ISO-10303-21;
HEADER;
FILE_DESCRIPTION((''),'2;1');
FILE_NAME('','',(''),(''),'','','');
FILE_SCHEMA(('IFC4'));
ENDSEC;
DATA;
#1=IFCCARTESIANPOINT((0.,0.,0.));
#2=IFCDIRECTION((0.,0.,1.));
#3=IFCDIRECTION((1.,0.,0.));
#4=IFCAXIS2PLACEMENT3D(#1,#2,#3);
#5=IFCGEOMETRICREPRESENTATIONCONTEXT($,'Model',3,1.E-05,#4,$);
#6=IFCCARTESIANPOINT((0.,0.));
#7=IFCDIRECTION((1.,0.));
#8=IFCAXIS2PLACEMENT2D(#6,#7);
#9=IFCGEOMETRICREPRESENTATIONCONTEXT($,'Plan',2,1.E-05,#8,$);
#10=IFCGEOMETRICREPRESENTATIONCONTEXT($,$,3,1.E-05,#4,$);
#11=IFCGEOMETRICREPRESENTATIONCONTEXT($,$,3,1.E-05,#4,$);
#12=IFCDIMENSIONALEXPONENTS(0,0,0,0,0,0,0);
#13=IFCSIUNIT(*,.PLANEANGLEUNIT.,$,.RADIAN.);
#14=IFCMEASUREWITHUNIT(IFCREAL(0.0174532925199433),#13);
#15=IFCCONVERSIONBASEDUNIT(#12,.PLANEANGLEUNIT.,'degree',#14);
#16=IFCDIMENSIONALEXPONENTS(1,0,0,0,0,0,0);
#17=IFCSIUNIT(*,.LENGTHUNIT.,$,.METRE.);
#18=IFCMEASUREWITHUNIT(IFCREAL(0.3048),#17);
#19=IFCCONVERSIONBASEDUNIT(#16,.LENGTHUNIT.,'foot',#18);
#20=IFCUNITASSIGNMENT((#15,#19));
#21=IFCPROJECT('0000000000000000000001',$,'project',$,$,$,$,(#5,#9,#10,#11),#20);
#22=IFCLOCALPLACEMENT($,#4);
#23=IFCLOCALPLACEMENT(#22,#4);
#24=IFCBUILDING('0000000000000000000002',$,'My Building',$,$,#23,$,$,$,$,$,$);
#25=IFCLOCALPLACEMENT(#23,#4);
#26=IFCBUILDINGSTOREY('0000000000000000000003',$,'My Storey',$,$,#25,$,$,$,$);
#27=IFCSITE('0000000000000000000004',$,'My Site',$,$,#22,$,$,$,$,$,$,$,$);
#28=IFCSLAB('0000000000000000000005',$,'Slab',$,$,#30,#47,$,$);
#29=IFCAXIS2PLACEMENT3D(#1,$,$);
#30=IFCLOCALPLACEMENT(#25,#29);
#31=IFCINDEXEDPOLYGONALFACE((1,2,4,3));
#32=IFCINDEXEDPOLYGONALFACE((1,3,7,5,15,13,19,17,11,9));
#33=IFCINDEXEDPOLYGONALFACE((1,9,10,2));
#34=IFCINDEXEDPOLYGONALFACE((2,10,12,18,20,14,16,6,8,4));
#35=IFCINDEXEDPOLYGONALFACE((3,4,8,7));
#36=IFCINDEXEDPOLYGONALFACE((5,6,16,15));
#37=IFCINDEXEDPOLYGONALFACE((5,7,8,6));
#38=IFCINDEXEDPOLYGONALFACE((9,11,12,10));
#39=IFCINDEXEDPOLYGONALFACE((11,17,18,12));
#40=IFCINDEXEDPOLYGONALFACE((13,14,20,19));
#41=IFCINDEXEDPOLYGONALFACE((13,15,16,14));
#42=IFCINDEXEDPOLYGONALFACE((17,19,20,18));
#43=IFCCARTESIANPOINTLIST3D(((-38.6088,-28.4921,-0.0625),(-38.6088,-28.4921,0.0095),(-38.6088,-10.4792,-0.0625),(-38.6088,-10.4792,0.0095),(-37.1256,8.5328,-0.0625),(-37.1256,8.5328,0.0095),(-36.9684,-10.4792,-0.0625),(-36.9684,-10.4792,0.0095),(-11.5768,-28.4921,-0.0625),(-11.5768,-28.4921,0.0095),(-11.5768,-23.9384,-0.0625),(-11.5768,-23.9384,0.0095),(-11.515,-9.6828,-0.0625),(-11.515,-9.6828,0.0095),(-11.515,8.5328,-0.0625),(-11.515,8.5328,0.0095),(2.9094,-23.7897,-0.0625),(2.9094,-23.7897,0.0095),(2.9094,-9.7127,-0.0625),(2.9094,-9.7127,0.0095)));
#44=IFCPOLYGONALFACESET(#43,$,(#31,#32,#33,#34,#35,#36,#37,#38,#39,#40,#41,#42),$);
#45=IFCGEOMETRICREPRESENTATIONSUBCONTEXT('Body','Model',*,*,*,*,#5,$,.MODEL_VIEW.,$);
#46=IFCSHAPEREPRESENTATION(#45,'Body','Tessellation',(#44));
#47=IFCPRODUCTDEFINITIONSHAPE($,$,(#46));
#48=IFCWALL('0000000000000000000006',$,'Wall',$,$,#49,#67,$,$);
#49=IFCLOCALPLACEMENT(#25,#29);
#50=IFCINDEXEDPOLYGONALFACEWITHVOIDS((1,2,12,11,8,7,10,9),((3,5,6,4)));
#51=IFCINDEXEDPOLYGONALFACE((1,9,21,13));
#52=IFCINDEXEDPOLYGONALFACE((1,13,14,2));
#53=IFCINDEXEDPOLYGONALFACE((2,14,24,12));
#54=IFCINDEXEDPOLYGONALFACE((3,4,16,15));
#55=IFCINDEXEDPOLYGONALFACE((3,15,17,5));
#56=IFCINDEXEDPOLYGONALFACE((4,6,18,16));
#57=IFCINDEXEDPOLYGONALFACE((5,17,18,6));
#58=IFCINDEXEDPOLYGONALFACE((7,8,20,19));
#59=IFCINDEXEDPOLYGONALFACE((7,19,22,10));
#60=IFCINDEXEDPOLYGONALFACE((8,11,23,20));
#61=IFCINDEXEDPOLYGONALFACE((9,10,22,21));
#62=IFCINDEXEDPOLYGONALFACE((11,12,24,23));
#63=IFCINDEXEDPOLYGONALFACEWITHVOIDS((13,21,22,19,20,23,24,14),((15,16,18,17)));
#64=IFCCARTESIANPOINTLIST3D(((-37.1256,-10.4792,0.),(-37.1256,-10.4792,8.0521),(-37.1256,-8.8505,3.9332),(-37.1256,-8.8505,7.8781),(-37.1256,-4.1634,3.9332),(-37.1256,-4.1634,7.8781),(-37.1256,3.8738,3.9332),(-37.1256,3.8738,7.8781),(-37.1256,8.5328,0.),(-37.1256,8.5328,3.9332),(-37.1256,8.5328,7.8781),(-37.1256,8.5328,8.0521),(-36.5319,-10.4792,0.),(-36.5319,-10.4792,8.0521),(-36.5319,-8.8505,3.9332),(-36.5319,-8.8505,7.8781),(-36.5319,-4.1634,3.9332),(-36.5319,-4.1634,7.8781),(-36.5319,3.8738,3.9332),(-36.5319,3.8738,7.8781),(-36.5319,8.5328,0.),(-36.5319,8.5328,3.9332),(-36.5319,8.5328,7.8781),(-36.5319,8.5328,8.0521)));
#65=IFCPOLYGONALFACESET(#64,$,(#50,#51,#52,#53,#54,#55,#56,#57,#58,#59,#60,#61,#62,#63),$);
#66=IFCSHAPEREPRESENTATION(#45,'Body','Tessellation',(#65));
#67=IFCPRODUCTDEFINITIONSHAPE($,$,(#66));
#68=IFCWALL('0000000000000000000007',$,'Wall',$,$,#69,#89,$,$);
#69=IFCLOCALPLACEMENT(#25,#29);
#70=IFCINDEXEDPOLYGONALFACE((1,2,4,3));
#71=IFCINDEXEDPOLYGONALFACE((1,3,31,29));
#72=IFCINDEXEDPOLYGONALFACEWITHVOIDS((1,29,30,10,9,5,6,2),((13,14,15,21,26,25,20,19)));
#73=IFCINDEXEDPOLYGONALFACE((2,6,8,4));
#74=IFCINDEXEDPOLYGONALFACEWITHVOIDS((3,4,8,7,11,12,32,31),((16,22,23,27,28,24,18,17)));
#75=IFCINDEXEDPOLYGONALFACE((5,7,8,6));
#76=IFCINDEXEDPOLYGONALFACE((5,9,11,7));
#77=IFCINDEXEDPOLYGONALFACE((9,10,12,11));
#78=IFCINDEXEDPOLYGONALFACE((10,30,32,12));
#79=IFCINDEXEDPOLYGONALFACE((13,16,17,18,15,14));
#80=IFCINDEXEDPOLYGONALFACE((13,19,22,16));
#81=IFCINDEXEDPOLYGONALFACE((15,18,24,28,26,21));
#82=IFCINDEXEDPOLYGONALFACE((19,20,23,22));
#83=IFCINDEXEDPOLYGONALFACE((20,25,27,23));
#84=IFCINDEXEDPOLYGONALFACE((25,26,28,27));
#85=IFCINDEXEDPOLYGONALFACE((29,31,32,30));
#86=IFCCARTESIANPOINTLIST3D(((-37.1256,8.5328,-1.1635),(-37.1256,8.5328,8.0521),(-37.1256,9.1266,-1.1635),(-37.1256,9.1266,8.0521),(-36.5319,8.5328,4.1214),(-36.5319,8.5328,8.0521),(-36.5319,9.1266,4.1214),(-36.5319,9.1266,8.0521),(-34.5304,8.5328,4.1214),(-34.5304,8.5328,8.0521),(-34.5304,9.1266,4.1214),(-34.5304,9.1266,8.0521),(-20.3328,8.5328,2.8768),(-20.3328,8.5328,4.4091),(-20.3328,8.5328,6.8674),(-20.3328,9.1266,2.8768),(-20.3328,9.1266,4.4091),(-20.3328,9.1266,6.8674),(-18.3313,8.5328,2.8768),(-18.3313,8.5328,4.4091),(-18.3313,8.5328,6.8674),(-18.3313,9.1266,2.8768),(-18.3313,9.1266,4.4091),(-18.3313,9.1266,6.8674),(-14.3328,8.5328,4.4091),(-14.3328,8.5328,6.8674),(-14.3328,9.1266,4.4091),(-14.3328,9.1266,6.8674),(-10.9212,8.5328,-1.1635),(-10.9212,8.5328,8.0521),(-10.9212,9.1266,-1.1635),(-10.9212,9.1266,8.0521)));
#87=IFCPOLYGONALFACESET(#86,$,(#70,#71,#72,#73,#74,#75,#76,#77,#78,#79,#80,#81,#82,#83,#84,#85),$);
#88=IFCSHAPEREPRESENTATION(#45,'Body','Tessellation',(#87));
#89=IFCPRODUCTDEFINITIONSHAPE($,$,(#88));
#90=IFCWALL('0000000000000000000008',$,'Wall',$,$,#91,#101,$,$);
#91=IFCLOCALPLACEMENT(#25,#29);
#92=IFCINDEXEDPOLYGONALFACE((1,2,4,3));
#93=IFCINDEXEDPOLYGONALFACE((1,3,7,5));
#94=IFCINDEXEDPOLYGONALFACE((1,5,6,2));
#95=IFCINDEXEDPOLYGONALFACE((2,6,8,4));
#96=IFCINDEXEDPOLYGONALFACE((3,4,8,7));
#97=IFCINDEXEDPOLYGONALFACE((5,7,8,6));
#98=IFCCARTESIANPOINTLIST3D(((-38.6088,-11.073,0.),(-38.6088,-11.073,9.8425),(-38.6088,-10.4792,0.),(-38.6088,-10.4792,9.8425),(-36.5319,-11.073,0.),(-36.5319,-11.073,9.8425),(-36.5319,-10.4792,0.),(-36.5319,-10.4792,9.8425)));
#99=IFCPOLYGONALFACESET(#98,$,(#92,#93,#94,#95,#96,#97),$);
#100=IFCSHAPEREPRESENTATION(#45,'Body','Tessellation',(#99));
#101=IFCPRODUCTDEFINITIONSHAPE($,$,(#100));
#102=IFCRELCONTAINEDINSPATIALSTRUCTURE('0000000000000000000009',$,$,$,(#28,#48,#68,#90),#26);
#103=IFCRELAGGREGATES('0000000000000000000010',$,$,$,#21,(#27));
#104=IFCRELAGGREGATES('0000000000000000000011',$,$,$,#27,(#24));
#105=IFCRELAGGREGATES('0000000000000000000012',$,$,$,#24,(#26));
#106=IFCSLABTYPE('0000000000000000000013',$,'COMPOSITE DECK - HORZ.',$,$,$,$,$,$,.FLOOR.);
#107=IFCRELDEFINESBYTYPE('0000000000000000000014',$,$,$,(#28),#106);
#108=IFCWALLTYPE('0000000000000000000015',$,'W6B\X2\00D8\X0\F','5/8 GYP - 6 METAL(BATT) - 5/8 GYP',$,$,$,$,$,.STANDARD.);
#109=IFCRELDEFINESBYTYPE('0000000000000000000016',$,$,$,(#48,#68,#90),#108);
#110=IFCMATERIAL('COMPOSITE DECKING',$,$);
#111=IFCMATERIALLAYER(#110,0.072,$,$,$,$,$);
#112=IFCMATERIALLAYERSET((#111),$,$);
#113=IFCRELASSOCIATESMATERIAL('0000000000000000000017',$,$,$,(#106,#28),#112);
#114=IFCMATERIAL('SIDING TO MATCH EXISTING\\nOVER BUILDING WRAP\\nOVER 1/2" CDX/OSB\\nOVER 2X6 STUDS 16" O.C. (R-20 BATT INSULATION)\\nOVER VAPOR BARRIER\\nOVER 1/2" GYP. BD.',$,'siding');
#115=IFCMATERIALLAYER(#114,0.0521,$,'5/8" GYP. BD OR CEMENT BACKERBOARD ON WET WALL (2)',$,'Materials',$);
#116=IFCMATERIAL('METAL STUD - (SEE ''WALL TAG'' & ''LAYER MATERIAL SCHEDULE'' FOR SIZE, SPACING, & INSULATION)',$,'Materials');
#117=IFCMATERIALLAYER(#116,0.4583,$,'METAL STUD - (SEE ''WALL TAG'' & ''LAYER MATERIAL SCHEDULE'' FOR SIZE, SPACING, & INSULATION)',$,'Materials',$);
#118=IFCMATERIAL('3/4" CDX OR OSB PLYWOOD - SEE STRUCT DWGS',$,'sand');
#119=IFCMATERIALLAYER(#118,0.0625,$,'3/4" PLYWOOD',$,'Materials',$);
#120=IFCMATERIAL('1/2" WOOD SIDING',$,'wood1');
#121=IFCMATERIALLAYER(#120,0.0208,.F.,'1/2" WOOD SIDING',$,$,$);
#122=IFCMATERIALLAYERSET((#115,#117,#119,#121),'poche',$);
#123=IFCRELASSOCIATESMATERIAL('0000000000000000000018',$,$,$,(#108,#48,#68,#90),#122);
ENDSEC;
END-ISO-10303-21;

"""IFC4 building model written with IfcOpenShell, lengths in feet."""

from ifc_helpers import new_model, entity, si_unit, converted_unit, frame, origin_with_axes, origin_2d_with_axis, place, context, subcontext, project, spatial, line, indexed_curve, outline, extrude, source, transform, mapped, material, layer, layer_set, layer_usage, type_object, element, save


model = new_model("IFC4")

# Units and contexts
model_context = context("Model", 3, precision=1e-05, world=origin_with_axes())
plan_context = context("Plan", 2, precision=1e-05, world=origin_2d_with_axis())
context_of_model_1 = context(None, 3, precision=1e-05, world=origin_with_axes())
context_of_model_2 = context(None, 3, precision=1e-05, world=origin_with_axes())
body_context = subcontext(model_context, "Body", "Model", "MODEL_VIEW")
ifc_project = project(units=[converted_unit("PLANEANGLEUNIT", "degree", entity("IfcReal", 0.0174532925199433), si_unit("PLANEANGLEUNIT", "RADIAN"), dimensions=[0, 0, 0, 0, 0, 0, 0]), converted_unit("LENGTHUNIT", "foot", entity("IfcReal", 0.3048), si_unit("LENGTHUNIT", "METRE"), dimensions=[1, 0, 0, 0, 0, 0, 0])], contexts=[model_context, plan_context, context_of_model_1, context_of_model_2])

# Site, building, storey
site_placement = place(None, origin_with_axes())
site = spatial("IfcSite", under=ifc_project, at=site_placement, Name="My Site")
building_placement = place(site_placement, origin_with_axes())
building = spatial("IfcBuilding", under=site, at=building_placement, Name="My Building")
storey_placement = place(building_placement, origin_with_axes())
storey = spatial("IfcBuildingStorey", under=building, at=storey_placement, Name="My Storey")

# Slab
ifc_material_1 = material(Name="COMPOSITE DECKING")
ifc_layer_1 = layer(ifc_material_1, 0.072)
ifc_layer_set_1 = layer_set([ifc_layer_1])
ifc_layer_usage_1 = layer_usage(ifc_layer_set_1, "AXIS3", "POSITIVE", 0.0)
slab_type_1 = type_object("IfcSlabType", Name="COMPOSITE DECK - HORZ.", PredefinedType="FLOOR", material=ifc_layer_set_1)
slab_1_placement = place(storey_placement, frame((-38.6088, -28.4921, -0.0625), z_axis=(0.0, 0.0, 1.0), x_axis=(1.0, 0.0, 0.0)))
element("IfcSlab", 1, at=slab_1_placement, inside=storey, type_object=slab_type_1, material=ifc_layer_usage_1, Name="Slab", context=body_context, shape_type="SweptSolid", body=[
    extrude(outline(indexed_curve([(0.0, 18.0129), (0.0, 0.0), (27.032, 0.0), (27.032, 4.5537), (41.5182, 4.7023), (41.5182, 18.7794), (27.0938, 18.8093), (27.0938, 37.0249), (1.4832, 37.0249), (1.6404, 18.0129)], segments=[line(3, 2), line(2, 1), line(1, 10), line(10, 9), line(9, 8), line(8, 7), line(7, 6), line(6, 5), line(5, 4), line(4, 3)], self_intersect=False)), None, (0.0, 0.0, 1.0), 0.072),
])

# Walls, openings
ifc_material_2 = material(Name="1/2\" WOOD SIDING", Category="wood1")
ifc_material_3 = material(Name="METAL STUD - (SEE 'WALL TAG' & 'LAYER MATERIAL SCHEDULE' FOR SIZE, SPACING, & INSULATION)", Category="Materials")
ifc_material_4 = material(Name="SIDING TO MATCH EXISTING\\nOVER BUILDING WRAP\\nOVER 1/2\" CDX/OSB\\nOVER 2X6 STUDS 16\" O.C. (R-20 BATT INSULATION)\\nOVER VAPOR BARRIER\\nOVER 1/2\" GYP. BD.", Category="siding")
ifc_layer_2 = layer(ifc_material_4, 0.0521, Name="5/8\" GYP. BD OR CEMENT BACKERBOARD ON WET WALL (2)", Category="Materials")
ifc_layer_3 = layer(ifc_material_3, 0.4583, Name="METAL STUD - (SEE 'WALL TAG' & 'LAYER MATERIAL SCHEDULE' FOR SIZE, SPACING, & INSULATION)", Category="Materials")
ifc_material_5 = material(Name="3/4\" CDX OR OSB PLYWOOD - SEE STRUCT DWGS", Category="sand")
ifc_layer_4 = layer(ifc_material_5, 0.0625, Name="3/4\" PLYWOOD", Category="Materials")
ifc_layer_5 = layer(ifc_material_2, 0.0208, ventilated=False, Name="1/2\" WOOD SIDING")
ifc_layer_set_2 = layer_set([ifc_layer_2, ifc_layer_3, ifc_layer_4, ifc_layer_5], Name="poche")
ifc_layer_usage_2 = layer_usage(ifc_layer_set_2, "AXIS2", "POSITIVE", 0.0)
wall_type_1 = type_object("IfcWallType", Name="W6BØF", Description="5/8 GYP - 6 METAL(BATT) - 5/8 GYP", PredefinedType="STANDARD", material=ifc_layer_set_2)
wall_1_placement = place(storey_placement, frame((-36.5319, -10.4792, 0.0), z_axis=(0.0, 0.0, 1.0), x_axis=(0.0, 1.0, 0.0)))
wall_1 = element("IfcWall", 2, at=wall_1_placement, inside=storey, type_object=wall_type_1, material=ifc_layer_usage_2, Name="Wall", context=body_context, shape_type="SweptSolid", body=[
    extrude(outline(indexed_curve([(0.0, 0.0), (0.0, 0.5937), (19.0121, 0.5937), (19.0121, 0.0), (0.0, 0.0)], self_intersect=False)), origin_with_axes(), (0.0, 0.0, 1.0), 8.0521),
])
shared_shape_1 = source(origin_with_axes(), body_context, "Body", "SweptSolid", [
    extrude(outline(indexed_curve([(0.0, 0.0), (4.6871, 0.0), (4.6871, 3.945), (0.0, 3.945)], segments=[line(1, 2, 3, 4, 1)])), frame((0.0, -1.9685, 0.0), z_axis=(0.0, -1.0, 0.0), x_axis=(1.0, 0.0, 0.0)), (0.0, 0.0, -1.0), 3.937),
])
opening_1_placement = place(wall_1_placement, frame((14.353, 0.0, 3.9332), z_axis=(0.0, 0.0, 1.0), x_axis=(1.0, 0.0, 0.0)))
element("IfcOpeningElement", 3, at=opening_1_placement, cuts=wall_1, PredefinedType="OPENING", context=body_context, shape_type="MappedRepresentation", body=[
    mapped(shared_shape_1, transform((0.0, 0.0, 0.0), x_axis=(1.0, 0.0, 0.0), y_axis=(0.0, 1.0, 0.0), z_axis=(0.0, 0.0, 1.0), scale=1.0)),
])
opening_2_placement = place(wall_1_placement, frame((1.6287, 0.0, 3.9332), z_axis=(0.0, 0.0, 1.0), x_axis=(1.0, 0.0, 0.0)))
element("IfcOpeningElement", 4, at=opening_2_placement, cuts=wall_1, PredefinedType="OPENING", context=body_context, shape_type="MappedRepresentation", body=[
    mapped(shared_shape_1, transform((0.0, 0.0, 0.0), x_axis=(1.0, 0.0, 0.0), y_axis=(0.0, 1.0, 0.0), z_axis=(0.0, 0.0, 1.0), scale=1.0)),
])
ifc_layer_usage_3 = layer_usage(ifc_layer_set_2, "AXIS2", "POSITIVE", 0.0)
wall_2_placement = place(storey_placement, frame((-37.1256, 8.5328, -1.1635), z_axis=(0.0, 0.0, 1.0), x_axis=(1.0, 0.0, 0.0)))
wall_2 = element("IfcWall", 5, at=wall_2_placement, inside=storey, type_object=wall_type_1, material=ifc_layer_usage_3, Name="Wall", context=body_context, shape_type="SweptSolid", body=[
    extrude(outline(indexed_curve([(0.0, 0.0), (0.0, 0.5937), (26.2044, 0.5937), (26.2044, 0.0), (0.0, 0.0)], self_intersect=False)), origin_with_axes(), (0.0, 0.0, 1.0), 9.2156),
])
shared_shape_2 = source(origin_with_axes(), body_context, "Body", "SweptSolid", [
    extrude(outline(indexed_curve([(0.0, 0.0), (2.0015, 0.0), (2.0015, 3.9906), (0.0, 3.9906)], segments=[line(3, 2), line(2, 1), line(1, 4), line(4, 3)], self_intersect=False)), frame((0.0, -1.9685, 0.0), z_axis=(0.0, -1.0, 0.0), x_axis=(1.0, 0.0, 0.0)), (0.0, 0.0, -1.0), 3.937),
])
opening_3_placement = place(wall_2_placement, frame((16.7928, 0.2298, 4.0403), z_axis=(0.0, 0.0, 1.0), x_axis=(1.0, 0.0, 0.0)))
element("IfcOpeningElement", 6, at=opening_3_placement, cuts=wall_2, PredefinedType="OPENING", context=body_context, shape_type="MappedRepresentation", body=[
    mapped(shared_shape_2, transform((0.0, 0.0, 0.0), x_axis=(1.0, 0.0, 0.0), y_axis=(0.0, 1.0, 0.0), z_axis=(0.0, 0.0, 1.0), scale=1.0)),
])
opening_4_placement = place(wall_2_placement, frame((0.5937, 0.2001, 5.2848), z_axis=(0.0, 0.0, 1.0), x_axis=(1.0, 0.0, 0.0)))
element("IfcOpeningElement", 7, at=opening_4_placement, cuts=wall_2, PredefinedType="OPENING", context=body_context, shape_type="MappedRepresentation", body=[
    mapped(shared_shape_2, transform((0.0, 0.0, 0.0), x_axis=(1.0, 0.0, 0.0), y_axis=(0.0, 1.0, 0.0), z_axis=(0.0, 0.0, 1.0), scale=1.0)),
])
shared_shape_3 = source(origin_with_axes(), body_context, "Body", "SweptSolid", [
    extrude(outline(indexed_curve([(0.0, 0.0), (6.0, 0.0), (6.0, 2.4583), (0.0, 2.4583)], segments=[line(1, 2, 3, 4, 1)])), frame((0.0, -1.9685, 0.0), z_axis=(0.0, -1.0, 0.0), x_axis=(1.0, 0.0, 0.0)), (0.0, 0.0, -1.0), 3.937),
])
opening_5_placement = place(wall_2_placement, frame((16.7928, 0.1901, 5.5726), z_axis=(0.0, 0.0, 1.0), x_axis=(1.0, 0.0, 0.0)))
element("IfcOpeningElement", 8, at=opening_5_placement, cuts=wall_2, PredefinedType="OPENING", context=body_context, shape_type="MappedRepresentation", body=[
    mapped(shared_shape_3, transform((0.0, 0.0, 0.0), x_axis=(1.0, 0.0, 0.0), y_axis=(0.0, 1.0, 0.0), z_axis=(0.0, 0.0, 1.0), scale=1.0)),
])

# Wall
ifc_layer_usage_4 = layer_usage(ifc_layer_set_2, "AXIS2", "POSITIVE", 0.0)
wall_3_placement = place(storey_placement, frame((-38.6088, -11.073, 0.0), z_axis=(0.0, 0.0, 1.0), x_axis=(1.0, 0.0, 0.0)))
element("IfcWall", 9, at=wall_3_placement, inside=storey, type_object=wall_type_1, material=ifc_layer_usage_4, Name="Wall", context=body_context, shape_type="SweptSolid", body=[
    extrude(outline(indexed_curve([(0.0, 0.0), (0.0, 0.5937), (2.0769, 0.5937), (2.0769, 0.0), (0.0, 0.0)], self_intersect=False)), origin_with_axes(), (0.0, 0.0, 1.0), 9.8425),
])

save(model, "model.ifc")
